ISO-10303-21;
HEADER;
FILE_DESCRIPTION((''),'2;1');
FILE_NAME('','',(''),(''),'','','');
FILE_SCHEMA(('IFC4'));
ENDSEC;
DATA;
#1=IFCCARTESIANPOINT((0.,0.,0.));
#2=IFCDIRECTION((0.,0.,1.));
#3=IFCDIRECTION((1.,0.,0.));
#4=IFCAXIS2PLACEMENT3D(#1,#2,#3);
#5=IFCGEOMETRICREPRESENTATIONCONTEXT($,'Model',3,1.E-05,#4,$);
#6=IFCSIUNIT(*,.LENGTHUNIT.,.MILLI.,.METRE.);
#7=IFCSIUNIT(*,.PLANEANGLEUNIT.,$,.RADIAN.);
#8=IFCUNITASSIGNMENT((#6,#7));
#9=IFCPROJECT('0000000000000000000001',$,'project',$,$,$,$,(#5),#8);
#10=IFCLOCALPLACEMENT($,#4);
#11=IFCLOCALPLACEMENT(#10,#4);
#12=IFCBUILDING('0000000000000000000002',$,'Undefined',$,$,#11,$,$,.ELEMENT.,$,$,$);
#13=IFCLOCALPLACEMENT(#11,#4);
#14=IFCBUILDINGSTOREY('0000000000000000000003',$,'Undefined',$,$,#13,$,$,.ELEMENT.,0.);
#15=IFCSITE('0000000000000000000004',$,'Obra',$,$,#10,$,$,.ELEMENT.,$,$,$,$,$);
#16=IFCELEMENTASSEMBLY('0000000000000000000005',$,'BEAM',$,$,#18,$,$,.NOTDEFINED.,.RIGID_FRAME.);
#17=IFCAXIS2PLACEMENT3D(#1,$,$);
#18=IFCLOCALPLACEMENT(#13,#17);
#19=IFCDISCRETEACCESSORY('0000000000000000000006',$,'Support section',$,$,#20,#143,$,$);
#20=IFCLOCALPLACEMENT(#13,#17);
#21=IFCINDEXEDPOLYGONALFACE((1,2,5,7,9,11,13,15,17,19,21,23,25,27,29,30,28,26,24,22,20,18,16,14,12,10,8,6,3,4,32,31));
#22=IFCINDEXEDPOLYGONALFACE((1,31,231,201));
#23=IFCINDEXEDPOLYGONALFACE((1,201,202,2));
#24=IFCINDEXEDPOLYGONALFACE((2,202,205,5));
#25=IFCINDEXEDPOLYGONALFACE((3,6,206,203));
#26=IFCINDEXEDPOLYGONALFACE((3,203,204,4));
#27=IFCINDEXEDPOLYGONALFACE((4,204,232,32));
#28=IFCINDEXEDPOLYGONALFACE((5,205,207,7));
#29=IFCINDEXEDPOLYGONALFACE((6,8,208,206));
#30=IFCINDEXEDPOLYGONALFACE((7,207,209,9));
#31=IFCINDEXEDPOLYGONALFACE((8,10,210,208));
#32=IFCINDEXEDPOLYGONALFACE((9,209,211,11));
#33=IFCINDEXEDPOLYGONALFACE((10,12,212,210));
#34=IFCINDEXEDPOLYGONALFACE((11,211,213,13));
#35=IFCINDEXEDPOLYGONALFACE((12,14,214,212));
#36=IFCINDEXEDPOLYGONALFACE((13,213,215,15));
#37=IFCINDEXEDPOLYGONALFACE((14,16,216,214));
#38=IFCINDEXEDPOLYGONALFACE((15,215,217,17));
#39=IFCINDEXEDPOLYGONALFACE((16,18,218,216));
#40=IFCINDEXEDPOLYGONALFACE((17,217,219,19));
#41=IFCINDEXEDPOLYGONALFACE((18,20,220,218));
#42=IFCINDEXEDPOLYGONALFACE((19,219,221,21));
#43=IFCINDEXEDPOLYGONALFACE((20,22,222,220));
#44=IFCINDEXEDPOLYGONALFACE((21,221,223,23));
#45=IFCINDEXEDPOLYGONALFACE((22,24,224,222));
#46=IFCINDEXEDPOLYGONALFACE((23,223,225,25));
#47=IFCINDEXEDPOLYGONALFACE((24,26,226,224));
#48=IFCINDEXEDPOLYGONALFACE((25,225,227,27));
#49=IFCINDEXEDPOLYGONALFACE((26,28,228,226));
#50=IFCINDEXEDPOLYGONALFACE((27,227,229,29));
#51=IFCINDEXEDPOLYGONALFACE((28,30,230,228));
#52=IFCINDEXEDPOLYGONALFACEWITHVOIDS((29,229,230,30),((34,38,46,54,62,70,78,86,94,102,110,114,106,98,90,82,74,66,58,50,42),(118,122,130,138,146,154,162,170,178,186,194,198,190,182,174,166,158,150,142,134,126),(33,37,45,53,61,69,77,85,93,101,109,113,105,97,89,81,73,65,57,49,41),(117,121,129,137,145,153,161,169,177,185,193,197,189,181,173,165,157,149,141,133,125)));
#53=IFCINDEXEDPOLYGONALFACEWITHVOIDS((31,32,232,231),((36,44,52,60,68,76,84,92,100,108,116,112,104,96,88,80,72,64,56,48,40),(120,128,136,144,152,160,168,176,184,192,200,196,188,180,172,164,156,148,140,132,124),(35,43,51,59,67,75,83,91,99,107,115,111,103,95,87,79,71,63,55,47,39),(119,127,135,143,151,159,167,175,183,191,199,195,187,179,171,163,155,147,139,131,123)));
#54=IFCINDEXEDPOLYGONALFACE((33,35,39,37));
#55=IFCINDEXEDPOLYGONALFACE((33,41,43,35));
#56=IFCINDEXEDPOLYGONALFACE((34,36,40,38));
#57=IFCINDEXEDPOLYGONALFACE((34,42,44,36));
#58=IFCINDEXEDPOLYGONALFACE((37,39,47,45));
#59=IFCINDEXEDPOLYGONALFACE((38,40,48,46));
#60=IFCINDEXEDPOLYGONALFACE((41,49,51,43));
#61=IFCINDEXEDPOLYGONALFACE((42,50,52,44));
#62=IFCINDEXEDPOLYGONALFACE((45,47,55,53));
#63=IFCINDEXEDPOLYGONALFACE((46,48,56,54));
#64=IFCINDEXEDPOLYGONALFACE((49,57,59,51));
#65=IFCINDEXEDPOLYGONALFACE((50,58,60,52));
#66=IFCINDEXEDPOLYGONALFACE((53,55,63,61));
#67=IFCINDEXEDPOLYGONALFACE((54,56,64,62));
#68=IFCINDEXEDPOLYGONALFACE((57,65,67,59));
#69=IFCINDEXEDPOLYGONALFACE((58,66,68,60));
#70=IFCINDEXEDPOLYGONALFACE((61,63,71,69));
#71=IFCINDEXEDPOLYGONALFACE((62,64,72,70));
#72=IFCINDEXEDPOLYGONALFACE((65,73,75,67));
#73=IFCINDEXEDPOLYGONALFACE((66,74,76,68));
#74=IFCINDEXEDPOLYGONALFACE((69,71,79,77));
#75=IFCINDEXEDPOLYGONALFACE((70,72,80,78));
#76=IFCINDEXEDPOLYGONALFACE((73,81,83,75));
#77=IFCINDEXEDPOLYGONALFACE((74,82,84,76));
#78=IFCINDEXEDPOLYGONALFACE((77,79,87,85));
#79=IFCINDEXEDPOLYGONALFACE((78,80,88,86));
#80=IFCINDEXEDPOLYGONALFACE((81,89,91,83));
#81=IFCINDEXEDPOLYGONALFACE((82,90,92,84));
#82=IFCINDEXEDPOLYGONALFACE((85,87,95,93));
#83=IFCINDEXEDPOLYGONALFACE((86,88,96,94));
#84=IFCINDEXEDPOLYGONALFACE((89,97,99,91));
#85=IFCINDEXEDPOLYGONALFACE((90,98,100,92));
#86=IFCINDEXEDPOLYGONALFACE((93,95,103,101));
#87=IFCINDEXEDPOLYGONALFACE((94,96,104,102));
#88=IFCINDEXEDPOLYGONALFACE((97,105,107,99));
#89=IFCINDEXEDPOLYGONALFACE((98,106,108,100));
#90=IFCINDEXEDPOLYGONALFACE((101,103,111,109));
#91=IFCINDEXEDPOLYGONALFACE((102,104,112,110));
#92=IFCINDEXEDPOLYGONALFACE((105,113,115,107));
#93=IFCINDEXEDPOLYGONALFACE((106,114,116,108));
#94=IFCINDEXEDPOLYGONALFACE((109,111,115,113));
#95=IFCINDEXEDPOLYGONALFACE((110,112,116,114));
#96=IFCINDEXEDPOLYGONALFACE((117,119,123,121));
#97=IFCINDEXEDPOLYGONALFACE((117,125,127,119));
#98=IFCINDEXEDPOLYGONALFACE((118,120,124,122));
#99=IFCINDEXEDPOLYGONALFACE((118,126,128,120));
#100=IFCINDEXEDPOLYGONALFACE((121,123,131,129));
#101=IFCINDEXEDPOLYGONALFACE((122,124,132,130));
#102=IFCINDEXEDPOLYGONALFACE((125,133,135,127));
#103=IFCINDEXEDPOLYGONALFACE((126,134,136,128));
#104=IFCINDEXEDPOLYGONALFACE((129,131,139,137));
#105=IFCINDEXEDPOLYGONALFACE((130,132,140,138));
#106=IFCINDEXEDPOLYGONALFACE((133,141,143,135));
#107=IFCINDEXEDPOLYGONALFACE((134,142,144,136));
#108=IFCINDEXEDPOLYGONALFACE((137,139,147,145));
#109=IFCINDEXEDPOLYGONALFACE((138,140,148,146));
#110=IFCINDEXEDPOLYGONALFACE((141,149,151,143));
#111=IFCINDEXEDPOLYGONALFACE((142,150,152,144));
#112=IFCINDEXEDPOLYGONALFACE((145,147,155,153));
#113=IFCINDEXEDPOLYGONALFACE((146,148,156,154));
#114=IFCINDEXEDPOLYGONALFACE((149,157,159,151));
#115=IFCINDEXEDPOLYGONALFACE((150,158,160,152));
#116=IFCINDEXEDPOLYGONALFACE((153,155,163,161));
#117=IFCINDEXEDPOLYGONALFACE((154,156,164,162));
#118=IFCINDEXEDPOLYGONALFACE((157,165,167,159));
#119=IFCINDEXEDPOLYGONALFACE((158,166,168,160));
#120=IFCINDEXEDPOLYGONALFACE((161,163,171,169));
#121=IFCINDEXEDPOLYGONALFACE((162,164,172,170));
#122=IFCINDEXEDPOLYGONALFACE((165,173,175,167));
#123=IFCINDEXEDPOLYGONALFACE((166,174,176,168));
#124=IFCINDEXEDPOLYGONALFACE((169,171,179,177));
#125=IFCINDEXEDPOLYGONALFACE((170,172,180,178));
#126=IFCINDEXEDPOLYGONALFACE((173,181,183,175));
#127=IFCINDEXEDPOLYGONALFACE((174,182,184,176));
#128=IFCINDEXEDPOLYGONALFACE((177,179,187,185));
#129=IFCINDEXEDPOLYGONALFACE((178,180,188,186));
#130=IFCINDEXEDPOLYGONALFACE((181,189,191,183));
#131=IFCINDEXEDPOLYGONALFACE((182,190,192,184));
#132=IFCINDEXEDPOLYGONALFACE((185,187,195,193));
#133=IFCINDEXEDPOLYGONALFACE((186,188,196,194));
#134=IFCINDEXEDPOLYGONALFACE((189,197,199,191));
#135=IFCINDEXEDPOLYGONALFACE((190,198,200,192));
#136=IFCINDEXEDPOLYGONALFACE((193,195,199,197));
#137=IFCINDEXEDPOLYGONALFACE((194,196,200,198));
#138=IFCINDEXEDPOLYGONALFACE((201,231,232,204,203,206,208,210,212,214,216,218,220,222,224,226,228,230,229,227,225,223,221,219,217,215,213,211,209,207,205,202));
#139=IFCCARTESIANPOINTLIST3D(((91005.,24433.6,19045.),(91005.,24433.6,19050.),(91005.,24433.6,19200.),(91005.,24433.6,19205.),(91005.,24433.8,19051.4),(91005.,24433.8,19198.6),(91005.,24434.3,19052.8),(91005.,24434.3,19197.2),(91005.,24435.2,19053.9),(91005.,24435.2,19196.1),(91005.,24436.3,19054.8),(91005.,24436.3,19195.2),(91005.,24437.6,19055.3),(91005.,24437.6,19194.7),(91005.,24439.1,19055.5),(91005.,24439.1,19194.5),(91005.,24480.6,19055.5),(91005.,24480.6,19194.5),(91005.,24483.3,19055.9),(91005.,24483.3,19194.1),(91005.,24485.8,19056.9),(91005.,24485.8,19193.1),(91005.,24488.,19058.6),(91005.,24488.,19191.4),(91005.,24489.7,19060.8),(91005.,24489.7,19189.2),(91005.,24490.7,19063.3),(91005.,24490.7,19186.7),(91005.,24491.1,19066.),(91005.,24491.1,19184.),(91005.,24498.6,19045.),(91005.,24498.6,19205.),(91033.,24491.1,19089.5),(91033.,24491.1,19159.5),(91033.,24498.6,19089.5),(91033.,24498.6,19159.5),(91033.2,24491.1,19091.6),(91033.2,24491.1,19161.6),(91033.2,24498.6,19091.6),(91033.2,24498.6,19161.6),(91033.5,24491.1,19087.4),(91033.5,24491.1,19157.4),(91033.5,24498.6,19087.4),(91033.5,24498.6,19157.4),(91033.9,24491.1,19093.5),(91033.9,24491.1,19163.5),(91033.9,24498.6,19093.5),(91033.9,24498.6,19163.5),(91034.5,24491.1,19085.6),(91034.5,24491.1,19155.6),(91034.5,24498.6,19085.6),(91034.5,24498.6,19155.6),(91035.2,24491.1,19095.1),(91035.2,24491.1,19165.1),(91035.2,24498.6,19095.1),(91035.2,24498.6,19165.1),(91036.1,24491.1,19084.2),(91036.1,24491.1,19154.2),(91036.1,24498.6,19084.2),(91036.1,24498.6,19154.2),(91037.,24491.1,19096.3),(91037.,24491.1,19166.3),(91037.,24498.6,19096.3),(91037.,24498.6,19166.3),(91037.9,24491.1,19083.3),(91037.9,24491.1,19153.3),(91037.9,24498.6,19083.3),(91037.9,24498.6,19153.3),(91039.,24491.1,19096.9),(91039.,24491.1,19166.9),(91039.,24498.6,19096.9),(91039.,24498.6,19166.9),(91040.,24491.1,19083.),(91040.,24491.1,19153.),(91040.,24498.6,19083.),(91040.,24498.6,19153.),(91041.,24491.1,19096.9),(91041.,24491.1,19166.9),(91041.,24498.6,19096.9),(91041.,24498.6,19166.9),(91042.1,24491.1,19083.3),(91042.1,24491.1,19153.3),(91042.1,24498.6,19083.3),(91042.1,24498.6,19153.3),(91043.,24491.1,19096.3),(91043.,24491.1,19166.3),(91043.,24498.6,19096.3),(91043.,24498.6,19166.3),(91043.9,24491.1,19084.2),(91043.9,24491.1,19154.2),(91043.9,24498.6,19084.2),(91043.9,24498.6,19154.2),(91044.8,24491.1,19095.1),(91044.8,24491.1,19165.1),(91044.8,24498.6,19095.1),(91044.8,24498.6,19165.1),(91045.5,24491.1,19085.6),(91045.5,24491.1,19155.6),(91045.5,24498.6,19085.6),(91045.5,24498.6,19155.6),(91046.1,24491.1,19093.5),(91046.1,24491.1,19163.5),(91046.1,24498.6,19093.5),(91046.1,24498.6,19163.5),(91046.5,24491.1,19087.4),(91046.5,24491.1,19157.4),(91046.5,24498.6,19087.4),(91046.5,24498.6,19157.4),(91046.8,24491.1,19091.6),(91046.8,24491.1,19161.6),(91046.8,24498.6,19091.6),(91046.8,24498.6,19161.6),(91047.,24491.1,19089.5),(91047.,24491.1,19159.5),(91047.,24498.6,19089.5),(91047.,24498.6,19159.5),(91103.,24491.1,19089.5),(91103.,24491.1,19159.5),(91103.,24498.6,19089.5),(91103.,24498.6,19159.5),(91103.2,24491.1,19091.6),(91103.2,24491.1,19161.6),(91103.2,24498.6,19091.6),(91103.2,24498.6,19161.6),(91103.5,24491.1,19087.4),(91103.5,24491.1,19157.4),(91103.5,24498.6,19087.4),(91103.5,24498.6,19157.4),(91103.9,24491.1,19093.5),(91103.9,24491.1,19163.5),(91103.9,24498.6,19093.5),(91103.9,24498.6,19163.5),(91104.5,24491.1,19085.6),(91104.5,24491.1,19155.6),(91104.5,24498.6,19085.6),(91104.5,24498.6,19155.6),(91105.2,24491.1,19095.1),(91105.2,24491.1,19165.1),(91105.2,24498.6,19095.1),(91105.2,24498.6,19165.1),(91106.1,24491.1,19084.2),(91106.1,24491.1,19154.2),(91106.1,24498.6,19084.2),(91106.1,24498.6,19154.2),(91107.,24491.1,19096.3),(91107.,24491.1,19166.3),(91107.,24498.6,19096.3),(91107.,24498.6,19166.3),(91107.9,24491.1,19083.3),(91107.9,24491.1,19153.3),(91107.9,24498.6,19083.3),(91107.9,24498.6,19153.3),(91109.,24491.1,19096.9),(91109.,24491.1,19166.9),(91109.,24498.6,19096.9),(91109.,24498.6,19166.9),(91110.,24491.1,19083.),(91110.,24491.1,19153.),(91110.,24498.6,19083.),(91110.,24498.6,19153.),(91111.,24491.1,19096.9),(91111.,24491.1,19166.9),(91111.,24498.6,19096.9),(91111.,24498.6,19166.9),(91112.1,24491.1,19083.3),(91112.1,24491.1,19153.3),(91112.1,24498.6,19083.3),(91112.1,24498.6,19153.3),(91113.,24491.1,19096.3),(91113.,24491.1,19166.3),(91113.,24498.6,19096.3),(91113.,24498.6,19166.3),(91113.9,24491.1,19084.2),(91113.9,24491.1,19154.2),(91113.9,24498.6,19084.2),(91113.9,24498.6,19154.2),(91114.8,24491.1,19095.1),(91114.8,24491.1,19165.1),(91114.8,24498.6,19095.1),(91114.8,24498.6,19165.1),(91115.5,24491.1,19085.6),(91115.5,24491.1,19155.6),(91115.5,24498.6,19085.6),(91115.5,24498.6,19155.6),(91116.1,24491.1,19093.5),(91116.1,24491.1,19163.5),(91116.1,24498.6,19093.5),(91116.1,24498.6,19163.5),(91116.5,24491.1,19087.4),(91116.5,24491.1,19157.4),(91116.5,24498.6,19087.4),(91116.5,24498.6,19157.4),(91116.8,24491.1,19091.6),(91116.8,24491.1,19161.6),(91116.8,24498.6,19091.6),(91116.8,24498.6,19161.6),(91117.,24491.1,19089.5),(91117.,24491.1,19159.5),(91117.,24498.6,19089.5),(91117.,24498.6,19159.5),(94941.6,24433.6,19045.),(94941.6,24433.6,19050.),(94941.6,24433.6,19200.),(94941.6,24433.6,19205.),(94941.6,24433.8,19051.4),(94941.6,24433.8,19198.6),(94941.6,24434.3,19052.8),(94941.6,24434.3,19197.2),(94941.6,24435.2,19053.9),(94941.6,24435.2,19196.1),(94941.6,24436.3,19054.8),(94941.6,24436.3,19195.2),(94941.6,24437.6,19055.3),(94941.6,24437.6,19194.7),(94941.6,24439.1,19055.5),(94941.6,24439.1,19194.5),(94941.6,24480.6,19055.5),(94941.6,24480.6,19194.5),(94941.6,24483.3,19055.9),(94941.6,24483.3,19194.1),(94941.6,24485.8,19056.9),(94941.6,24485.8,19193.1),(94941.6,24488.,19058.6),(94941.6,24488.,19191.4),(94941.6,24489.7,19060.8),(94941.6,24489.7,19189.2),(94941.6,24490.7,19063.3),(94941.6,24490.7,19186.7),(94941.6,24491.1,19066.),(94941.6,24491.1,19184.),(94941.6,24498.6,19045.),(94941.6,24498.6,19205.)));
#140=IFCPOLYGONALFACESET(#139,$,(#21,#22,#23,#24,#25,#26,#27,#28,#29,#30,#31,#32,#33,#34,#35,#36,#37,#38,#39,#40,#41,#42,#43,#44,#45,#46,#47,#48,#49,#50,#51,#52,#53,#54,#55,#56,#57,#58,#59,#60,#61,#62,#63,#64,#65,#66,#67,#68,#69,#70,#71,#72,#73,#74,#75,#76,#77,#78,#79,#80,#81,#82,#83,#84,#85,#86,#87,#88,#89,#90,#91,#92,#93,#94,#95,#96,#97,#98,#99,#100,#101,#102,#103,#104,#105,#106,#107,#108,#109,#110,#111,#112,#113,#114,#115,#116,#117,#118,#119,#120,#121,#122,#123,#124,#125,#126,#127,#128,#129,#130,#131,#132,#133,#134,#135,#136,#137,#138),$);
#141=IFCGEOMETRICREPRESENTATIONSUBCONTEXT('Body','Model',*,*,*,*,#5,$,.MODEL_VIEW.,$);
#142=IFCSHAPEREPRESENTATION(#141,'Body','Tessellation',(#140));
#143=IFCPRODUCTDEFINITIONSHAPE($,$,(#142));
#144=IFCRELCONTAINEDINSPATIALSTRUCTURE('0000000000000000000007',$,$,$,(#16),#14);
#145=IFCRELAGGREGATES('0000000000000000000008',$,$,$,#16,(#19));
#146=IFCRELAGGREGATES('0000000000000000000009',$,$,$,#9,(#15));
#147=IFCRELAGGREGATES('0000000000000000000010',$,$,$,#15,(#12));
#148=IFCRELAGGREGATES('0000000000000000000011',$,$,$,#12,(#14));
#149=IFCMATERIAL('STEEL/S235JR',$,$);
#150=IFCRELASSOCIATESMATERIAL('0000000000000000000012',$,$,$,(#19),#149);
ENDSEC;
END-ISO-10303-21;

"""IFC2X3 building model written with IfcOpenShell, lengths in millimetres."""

from ifc_helpers import new_model, si_unit, frame, origin_with_axes, origin_2d_with_axis, place, context, subcontext, project, spatial, circle, u_section, extrude, clip, halfspace, source, transform, mapped, material, element, aggregate, save


model = new_model("IFC2X3")

# Units and contexts
model_context = context("Model", 3, precision=1e-05, world=origin_with_axes())
body_context = subcontext(model_context, "Body", "Model", "MODEL_VIEW")
ifc_project = project(units=[si_unit("LENGTHUNIT", "METRE", prefix="MILLI"), si_unit("PLANEANGLEUNIT", "RADIAN")], contexts=[model_context])

# Site, building, storey
site_placement = place(None, origin_with_axes())
site = spatial("IfcSite", under=ifc_project, at=site_placement, Name="Obra", CompositionType="ELEMENT")
building_placement = place(site_placement, origin_with_axes())
building = spatial("IfcBuilding", under=site, at=building_placement, Name="Undefined", CompositionType="ELEMENT")
storey_placement = place(building_placement, origin_with_axes())
storey = spatial("IfcBuildingStorey", under=building, at=storey_placement, Name="Undefined", CompositionType="ELEMENT", Elevation=0.0)

# Shared definitions
ifc_material_1 = material(Name="STEEL/S235JR")

# Element assembly
assembly_1_placement = place(storey_placement, origin_with_axes())
assembly_1 = element("IfcElementAssembly", 1, at=assembly_1_placement, inside=storey, Name="BEAM", AssemblyPlace="NOTDEFINED", PredefinedType="RIGID_FRAME")

# Discrete accessory, opening
discrete_accessory_1_placement = place(assembly_1_placement, frame((91000.0, 24466.1, 19125.0), z_axis=(0.0, 0.0, 1.0), x_axis=(1.0, 0.0, 0.0)))
discrete_accessory_1 = element("IfcDiscreteAccessory", 2, at=discrete_accessory_1_placement, material=ifc_material_1, Name="Support section", context=body_context, shape_type="Clipping", body=[
    clip(extrude(u_section(Depth=160.0, FlangeWidth=65.0, WebThickness=7.5, FlangeThickness=10.5, FilletRadius=10.5, EdgeRadius=5.5, at=origin_2d_with_axis()), frame((3941.6, 0.0, 0.0), z_axis=(-1.0, 0.0, 0.0), x_axis=(0.0, -1.0, 0.0)), (0.0, 0.0, 1.0), 3936.6), halfspace(frame((5.0, 0.0, 166.3), z_axis=(-1.0, 0.0, 0.0), x_axis=(0.0, -1.0, 0.0)), False)),
])
shared_shape_1 = source(origin_with_axes(), body_context, "Body", "SweptSolid", [
    extrude(circle(Radius=7.0, at=origin_2d_with_axis()), frame((0.0, -3.8, 0.0), z_axis=(0.0, 1.0, 0.0), x_axis=(1.0, 0.0, 0.0)), (0.0, 0.0, 1.0), 7.7),
])
opening_1_placement = place(assembly_1_placement, frame((91040.0, 24494.8, 19160.0), z_axis=(1.0, 0.0, 0.0), x_axis=(0.0, 0.0, -1.0)))
element("IfcOpeningElement", 3, at=opening_1_placement, cuts=discrete_accessory_1, ObjectType="Opening", context=body_context, shape_type="MappedRepresentation", body=[
    mapped(shared_shape_1, transform((0.0, 0.0, 0.0))),
    mapped(shared_shape_1, transform((0.0, 0.0, 70.0))),
    mapped(shared_shape_1, transform((70.0, 0.0, 0.0))),
    mapped(shared_shape_1, transform((70.0, 0.0, 70.0))),
])
aggregate(assembly_1, [discrete_accessory_1])

save(model, "model.ifc")
